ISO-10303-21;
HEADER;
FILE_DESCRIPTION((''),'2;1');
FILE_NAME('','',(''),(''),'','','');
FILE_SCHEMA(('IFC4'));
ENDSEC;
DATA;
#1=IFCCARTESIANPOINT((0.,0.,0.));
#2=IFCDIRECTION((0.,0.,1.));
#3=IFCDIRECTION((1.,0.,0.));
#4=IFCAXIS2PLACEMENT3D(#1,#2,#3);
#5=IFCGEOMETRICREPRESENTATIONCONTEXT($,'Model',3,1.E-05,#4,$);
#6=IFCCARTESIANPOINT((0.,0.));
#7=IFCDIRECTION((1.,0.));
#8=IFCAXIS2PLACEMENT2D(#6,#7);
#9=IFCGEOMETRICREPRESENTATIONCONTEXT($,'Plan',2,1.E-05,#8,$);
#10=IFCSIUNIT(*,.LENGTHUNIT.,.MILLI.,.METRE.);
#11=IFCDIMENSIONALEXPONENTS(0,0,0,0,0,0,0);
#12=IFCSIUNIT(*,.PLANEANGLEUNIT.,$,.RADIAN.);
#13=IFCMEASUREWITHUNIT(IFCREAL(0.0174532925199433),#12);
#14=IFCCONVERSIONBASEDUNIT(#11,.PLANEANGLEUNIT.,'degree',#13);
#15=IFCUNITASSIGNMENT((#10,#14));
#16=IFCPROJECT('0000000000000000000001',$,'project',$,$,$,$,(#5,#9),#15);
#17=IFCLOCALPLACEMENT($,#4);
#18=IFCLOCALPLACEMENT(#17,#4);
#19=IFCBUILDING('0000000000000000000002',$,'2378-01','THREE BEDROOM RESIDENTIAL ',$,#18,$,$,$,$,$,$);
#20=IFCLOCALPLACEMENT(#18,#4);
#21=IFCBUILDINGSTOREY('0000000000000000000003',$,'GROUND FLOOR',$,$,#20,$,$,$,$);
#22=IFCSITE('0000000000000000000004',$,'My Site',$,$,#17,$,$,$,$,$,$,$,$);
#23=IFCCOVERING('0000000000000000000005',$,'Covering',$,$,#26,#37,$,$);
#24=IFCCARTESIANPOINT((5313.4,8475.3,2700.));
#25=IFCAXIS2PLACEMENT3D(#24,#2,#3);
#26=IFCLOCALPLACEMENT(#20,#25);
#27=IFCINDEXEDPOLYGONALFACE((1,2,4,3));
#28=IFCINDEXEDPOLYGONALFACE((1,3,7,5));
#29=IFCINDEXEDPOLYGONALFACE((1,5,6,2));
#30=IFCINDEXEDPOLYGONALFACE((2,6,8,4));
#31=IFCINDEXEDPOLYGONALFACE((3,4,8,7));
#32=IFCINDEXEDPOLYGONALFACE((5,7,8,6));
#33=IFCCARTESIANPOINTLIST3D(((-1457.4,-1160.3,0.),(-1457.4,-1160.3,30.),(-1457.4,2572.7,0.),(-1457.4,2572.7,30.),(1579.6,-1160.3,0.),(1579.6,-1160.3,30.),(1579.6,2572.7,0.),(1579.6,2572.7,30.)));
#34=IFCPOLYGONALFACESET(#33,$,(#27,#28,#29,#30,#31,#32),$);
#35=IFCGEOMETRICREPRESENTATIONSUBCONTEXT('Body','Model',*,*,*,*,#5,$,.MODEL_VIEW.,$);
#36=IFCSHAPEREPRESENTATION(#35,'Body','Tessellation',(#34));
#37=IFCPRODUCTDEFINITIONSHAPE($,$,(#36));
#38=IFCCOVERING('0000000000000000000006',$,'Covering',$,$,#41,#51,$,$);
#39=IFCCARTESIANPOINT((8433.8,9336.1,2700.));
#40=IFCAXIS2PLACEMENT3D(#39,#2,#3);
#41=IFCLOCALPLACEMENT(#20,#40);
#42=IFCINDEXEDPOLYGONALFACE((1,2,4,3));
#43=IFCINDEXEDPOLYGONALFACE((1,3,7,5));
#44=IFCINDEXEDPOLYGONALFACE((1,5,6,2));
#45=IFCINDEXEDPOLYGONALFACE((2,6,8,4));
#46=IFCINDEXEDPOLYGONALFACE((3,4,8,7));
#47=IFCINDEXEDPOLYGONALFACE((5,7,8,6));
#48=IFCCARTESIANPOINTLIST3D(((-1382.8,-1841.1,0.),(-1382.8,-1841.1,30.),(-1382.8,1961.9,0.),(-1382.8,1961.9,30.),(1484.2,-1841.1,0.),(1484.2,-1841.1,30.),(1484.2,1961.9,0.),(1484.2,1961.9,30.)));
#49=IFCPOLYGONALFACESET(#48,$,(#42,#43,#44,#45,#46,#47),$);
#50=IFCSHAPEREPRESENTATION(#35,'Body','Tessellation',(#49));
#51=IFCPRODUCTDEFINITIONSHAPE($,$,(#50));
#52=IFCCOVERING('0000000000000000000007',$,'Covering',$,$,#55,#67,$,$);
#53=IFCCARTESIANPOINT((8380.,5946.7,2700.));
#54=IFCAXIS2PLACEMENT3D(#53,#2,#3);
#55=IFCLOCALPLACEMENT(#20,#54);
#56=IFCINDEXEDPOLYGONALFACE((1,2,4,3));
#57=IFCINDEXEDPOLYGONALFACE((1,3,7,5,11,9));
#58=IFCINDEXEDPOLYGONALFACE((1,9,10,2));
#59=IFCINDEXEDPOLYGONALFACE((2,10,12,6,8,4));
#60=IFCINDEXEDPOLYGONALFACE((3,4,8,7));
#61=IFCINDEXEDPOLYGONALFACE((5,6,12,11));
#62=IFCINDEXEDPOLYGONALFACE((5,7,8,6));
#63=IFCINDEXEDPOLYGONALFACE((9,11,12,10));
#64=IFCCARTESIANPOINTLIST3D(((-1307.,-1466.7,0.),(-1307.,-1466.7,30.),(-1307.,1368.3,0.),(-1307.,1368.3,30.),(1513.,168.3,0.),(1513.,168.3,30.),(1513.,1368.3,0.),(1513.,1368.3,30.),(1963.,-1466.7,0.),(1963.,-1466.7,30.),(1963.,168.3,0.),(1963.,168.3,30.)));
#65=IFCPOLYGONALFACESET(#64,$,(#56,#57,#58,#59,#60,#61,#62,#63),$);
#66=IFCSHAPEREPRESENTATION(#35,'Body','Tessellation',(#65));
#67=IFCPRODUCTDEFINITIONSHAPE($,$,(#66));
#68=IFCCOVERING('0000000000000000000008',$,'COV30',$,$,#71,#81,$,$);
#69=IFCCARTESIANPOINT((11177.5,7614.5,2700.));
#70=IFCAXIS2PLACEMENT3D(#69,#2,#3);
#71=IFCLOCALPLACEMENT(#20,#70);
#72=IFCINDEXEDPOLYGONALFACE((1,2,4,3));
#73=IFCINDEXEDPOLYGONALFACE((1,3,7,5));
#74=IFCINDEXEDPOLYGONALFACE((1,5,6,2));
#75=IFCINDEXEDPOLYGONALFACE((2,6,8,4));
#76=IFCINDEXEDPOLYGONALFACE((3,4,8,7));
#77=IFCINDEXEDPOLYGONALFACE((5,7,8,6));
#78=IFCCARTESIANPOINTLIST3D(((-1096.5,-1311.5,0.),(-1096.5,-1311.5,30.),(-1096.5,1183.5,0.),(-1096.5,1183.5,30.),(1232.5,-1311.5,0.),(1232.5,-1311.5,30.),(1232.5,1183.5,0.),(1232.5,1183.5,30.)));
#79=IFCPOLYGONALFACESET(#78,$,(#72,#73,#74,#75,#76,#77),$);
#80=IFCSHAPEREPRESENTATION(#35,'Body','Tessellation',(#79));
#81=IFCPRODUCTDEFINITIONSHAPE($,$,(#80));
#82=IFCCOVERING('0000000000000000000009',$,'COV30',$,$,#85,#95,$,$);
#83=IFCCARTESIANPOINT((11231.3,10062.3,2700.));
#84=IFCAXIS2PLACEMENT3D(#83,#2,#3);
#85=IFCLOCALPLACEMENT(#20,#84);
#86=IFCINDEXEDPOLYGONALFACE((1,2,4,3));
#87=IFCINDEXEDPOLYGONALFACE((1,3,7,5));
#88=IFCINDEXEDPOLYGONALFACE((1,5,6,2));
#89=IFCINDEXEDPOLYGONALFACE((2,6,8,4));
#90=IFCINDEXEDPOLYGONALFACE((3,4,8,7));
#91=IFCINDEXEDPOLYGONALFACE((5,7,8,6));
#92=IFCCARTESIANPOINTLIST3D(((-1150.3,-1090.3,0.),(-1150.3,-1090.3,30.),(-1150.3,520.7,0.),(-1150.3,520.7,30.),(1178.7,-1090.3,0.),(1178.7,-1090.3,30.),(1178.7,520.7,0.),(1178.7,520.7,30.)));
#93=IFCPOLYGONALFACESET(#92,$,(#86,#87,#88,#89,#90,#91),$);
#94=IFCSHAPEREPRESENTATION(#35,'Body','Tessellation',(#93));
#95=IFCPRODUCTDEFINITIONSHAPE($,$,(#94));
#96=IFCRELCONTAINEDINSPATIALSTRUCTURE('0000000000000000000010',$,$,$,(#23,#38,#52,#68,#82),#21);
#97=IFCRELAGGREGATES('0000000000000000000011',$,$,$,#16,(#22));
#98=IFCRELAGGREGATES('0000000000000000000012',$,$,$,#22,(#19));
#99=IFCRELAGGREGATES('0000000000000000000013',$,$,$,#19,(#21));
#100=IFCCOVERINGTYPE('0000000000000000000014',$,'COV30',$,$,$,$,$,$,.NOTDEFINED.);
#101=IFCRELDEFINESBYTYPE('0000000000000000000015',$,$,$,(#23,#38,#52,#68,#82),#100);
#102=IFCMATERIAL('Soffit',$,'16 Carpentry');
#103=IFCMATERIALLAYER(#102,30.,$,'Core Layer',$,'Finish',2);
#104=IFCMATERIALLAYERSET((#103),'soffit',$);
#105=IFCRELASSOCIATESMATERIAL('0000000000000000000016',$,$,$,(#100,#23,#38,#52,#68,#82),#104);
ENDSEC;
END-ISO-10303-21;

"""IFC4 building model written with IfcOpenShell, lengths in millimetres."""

from ifc_helpers import new_model, entity, si_unit, converted_unit, frame, origin_with_axes, origin_2d_with_axis, place, context, subcontext, project, spatial, line, indexed_curve, outline, extrude, material, layer, layer_set, layer_usage, type_object, element, save


model = new_model("IFC4")

# Units and contexts
model_context = context("Model", 3, precision=1e-05, world=origin_with_axes())
plan_context = context("Plan", 2, precision=1e-05, world=origin_2d_with_axis())
body_context_1 = subcontext(model_context, "Body", "Model", "MODEL_VIEW")
ifc_project = project(units=[si_unit("LENGTHUNIT", "METRE", prefix="MILLI"), converted_unit("PLANEANGLEUNIT", "degree", entity("IfcReal", 0.0174532925199433), si_unit("PLANEANGLEUNIT", "RADIAN"), dimensions=[0, 0, 0, 0, 0, 0, 0])], contexts=[model_context, plan_context])

# Site, building, storey
site_placement = place(None, origin_with_axes())
site = spatial("IfcSite", under=ifc_project, at=site_placement, Name="My Site")
building_placement = place(site_placement, origin_with_axes())
building = spatial("IfcBuilding", under=site, at=building_placement, Name="2378-01", Description="THREE BEDROOM RESIDENTIAL ")
storey_placement = place(building_placement, origin_with_axes())
storey = spatial("IfcBuildingStorey", under=building, at=storey_placement, Name="GROUND FLOOR")

# Coverings
ifc_material_1 = material(Name="Soffit", Category="16 Carpentry")
ifc_layer_1 = layer(ifc_material_1, 30.0, Name="Core Layer", Category="Finish", Priority=2)
ifc_layer_set_1 = layer_set([ifc_layer_1], Name="soffit")
ifc_layer_usage_1 = layer_usage(ifc_layer_set_1, "AXIS3", "POSITIVE", 0.0)
covering_type = type_object("IfcCoveringType", Name="COV30", PredefinedType="NOTDEFINED", material=ifc_layer_set_1)
covering_1_placement = place(storey_placement, frame((5313.4, 8475.3, 2700.0), z_axis=(0.0, 0.0, 1.0), x_axis=(1.0, 0.0, 0.0)))
element("IfcCovering", 1, at=covering_1_placement, inside=storey, type_object=covering_type, material=ifc_layer_usage_1, Name="Covering", context=body_context_1, shape_type="SweptSolid", body=[
    extrude(outline(indexed_curve([(-1457.4, -1160.3), (-1457.4, 2572.7), (1579.6, 2572.7), (1579.6, -1160.3), (-1457.4, -1160.3)], segments=[line(1, 2, 3, 4, 5, 1)])), None, (0.0, 0.0, 1.0), 30.0),
])
ifc_layer_usage_2 = layer_usage(ifc_layer_set_1, "AXIS3", "POSITIVE", 0.0)
covering_2_placement = place(storey_placement, frame((8433.8, 9336.1, 2700.0), z_axis=(0.0, 0.0, 1.0), x_axis=(1.0, 0.0, 0.0)))
element("IfcCovering", 2, at=covering_2_placement, inside=storey, type_object=covering_type, material=ifc_layer_usage_2, Name="Covering", context=body_context_1, shape_type="SweptSolid", body=[
    extrude(outline(indexed_curve([(1484.2, 1961.9), (1484.2, -1841.1), (-1382.8, -1841.1), (-1382.8, 1961.9), (1484.2, 1961.9)], segments=[line(1, 2, 3, 4, 5, 1)])), None, (0.0, 0.0, 1.0), 30.0),
])
ifc_layer_usage_3 = layer_usage(ifc_layer_set_1, "AXIS3", "POSITIVE", 0.0)
covering_3_placement = place(storey_placement, frame((8380.0, 5946.7, 2700.0), z_axis=(0.0, 0.0, 1.0), x_axis=(1.0, 0.0, 0.0)))
element("IfcCovering", 3, at=covering_3_placement, inside=storey, type_object=covering_type, material=ifc_layer_usage_3, Name="Covering", context=body_context_1, shape_type="SweptSolid", body=[
    extrude(outline(indexed_curve([(1963.0, -1466.7), (-1307.0, -1466.7), (-1307.0, 1368.3), (1513.0, 1368.3), (1513.0, 168.3), (1963.0, 168.3), (1963.0, -1466.7)], segments=[line(1, 2, 3, 4, 5, 6, 7, 1)])), None, (0.0, 0.0, 1.0), 30.0),
])
ifc_layer_usage_4 = layer_usage(ifc_layer_set_1, "AXIS3", "POSITIVE", 0.0)
covering_4_placement = place(storey_placement, frame((11177.5, 7614.5, 2700.0), z_axis=(0.0, 0.0, 1.0), x_axis=(1.0, 0.0, 0.0)))
element("IfcCovering", 4, at=covering_4_placement, inside=storey, type_object=covering_type, material=ifc_layer_usage_4, Name="COV30", context=body_context_1, shape_type="SweptSolid", body=[
    extrude(outline(indexed_curve([(-1096.5, 1183.5), (1232.5, 1183.5), (1232.5, -1311.5), (-1096.5, -1311.5), (-1096.5, 1183.5)], segments=[line(1, 2, 3, 4, 5, 1)])), None, (0.0, 0.0, 1.0), 30.0),
])
ifc_layer_usage_5 = layer_usage(ifc_layer_set_1, "AXIS3", "POSITIVE", 0.0)
covering_5_placement = place(storey_placement, frame((11231.3, 10062.3, 2700.0), z_axis=(0.0, 0.0, 1.0), x_axis=(1.0, 0.0, 0.0)))
element("IfcCovering", 5, at=covering_5_placement, inside=storey, type_object=covering_type, material=ifc_layer_usage_5, Name="COV30", context=body_context_1, shape_type="SweptSolid", body=[
    extrude(outline(indexed_curve([(-1150.3, 520.7), (1178.7, 520.7), (1178.7, -1090.3), (-1150.3, -1090.3), (-1150.3, 520.7)], segments=[line(1, 2, 3, 4, 5, 1)])), None, (0.0, 0.0, 1.0), 30.0),
])

save(model, "model.ifc")
